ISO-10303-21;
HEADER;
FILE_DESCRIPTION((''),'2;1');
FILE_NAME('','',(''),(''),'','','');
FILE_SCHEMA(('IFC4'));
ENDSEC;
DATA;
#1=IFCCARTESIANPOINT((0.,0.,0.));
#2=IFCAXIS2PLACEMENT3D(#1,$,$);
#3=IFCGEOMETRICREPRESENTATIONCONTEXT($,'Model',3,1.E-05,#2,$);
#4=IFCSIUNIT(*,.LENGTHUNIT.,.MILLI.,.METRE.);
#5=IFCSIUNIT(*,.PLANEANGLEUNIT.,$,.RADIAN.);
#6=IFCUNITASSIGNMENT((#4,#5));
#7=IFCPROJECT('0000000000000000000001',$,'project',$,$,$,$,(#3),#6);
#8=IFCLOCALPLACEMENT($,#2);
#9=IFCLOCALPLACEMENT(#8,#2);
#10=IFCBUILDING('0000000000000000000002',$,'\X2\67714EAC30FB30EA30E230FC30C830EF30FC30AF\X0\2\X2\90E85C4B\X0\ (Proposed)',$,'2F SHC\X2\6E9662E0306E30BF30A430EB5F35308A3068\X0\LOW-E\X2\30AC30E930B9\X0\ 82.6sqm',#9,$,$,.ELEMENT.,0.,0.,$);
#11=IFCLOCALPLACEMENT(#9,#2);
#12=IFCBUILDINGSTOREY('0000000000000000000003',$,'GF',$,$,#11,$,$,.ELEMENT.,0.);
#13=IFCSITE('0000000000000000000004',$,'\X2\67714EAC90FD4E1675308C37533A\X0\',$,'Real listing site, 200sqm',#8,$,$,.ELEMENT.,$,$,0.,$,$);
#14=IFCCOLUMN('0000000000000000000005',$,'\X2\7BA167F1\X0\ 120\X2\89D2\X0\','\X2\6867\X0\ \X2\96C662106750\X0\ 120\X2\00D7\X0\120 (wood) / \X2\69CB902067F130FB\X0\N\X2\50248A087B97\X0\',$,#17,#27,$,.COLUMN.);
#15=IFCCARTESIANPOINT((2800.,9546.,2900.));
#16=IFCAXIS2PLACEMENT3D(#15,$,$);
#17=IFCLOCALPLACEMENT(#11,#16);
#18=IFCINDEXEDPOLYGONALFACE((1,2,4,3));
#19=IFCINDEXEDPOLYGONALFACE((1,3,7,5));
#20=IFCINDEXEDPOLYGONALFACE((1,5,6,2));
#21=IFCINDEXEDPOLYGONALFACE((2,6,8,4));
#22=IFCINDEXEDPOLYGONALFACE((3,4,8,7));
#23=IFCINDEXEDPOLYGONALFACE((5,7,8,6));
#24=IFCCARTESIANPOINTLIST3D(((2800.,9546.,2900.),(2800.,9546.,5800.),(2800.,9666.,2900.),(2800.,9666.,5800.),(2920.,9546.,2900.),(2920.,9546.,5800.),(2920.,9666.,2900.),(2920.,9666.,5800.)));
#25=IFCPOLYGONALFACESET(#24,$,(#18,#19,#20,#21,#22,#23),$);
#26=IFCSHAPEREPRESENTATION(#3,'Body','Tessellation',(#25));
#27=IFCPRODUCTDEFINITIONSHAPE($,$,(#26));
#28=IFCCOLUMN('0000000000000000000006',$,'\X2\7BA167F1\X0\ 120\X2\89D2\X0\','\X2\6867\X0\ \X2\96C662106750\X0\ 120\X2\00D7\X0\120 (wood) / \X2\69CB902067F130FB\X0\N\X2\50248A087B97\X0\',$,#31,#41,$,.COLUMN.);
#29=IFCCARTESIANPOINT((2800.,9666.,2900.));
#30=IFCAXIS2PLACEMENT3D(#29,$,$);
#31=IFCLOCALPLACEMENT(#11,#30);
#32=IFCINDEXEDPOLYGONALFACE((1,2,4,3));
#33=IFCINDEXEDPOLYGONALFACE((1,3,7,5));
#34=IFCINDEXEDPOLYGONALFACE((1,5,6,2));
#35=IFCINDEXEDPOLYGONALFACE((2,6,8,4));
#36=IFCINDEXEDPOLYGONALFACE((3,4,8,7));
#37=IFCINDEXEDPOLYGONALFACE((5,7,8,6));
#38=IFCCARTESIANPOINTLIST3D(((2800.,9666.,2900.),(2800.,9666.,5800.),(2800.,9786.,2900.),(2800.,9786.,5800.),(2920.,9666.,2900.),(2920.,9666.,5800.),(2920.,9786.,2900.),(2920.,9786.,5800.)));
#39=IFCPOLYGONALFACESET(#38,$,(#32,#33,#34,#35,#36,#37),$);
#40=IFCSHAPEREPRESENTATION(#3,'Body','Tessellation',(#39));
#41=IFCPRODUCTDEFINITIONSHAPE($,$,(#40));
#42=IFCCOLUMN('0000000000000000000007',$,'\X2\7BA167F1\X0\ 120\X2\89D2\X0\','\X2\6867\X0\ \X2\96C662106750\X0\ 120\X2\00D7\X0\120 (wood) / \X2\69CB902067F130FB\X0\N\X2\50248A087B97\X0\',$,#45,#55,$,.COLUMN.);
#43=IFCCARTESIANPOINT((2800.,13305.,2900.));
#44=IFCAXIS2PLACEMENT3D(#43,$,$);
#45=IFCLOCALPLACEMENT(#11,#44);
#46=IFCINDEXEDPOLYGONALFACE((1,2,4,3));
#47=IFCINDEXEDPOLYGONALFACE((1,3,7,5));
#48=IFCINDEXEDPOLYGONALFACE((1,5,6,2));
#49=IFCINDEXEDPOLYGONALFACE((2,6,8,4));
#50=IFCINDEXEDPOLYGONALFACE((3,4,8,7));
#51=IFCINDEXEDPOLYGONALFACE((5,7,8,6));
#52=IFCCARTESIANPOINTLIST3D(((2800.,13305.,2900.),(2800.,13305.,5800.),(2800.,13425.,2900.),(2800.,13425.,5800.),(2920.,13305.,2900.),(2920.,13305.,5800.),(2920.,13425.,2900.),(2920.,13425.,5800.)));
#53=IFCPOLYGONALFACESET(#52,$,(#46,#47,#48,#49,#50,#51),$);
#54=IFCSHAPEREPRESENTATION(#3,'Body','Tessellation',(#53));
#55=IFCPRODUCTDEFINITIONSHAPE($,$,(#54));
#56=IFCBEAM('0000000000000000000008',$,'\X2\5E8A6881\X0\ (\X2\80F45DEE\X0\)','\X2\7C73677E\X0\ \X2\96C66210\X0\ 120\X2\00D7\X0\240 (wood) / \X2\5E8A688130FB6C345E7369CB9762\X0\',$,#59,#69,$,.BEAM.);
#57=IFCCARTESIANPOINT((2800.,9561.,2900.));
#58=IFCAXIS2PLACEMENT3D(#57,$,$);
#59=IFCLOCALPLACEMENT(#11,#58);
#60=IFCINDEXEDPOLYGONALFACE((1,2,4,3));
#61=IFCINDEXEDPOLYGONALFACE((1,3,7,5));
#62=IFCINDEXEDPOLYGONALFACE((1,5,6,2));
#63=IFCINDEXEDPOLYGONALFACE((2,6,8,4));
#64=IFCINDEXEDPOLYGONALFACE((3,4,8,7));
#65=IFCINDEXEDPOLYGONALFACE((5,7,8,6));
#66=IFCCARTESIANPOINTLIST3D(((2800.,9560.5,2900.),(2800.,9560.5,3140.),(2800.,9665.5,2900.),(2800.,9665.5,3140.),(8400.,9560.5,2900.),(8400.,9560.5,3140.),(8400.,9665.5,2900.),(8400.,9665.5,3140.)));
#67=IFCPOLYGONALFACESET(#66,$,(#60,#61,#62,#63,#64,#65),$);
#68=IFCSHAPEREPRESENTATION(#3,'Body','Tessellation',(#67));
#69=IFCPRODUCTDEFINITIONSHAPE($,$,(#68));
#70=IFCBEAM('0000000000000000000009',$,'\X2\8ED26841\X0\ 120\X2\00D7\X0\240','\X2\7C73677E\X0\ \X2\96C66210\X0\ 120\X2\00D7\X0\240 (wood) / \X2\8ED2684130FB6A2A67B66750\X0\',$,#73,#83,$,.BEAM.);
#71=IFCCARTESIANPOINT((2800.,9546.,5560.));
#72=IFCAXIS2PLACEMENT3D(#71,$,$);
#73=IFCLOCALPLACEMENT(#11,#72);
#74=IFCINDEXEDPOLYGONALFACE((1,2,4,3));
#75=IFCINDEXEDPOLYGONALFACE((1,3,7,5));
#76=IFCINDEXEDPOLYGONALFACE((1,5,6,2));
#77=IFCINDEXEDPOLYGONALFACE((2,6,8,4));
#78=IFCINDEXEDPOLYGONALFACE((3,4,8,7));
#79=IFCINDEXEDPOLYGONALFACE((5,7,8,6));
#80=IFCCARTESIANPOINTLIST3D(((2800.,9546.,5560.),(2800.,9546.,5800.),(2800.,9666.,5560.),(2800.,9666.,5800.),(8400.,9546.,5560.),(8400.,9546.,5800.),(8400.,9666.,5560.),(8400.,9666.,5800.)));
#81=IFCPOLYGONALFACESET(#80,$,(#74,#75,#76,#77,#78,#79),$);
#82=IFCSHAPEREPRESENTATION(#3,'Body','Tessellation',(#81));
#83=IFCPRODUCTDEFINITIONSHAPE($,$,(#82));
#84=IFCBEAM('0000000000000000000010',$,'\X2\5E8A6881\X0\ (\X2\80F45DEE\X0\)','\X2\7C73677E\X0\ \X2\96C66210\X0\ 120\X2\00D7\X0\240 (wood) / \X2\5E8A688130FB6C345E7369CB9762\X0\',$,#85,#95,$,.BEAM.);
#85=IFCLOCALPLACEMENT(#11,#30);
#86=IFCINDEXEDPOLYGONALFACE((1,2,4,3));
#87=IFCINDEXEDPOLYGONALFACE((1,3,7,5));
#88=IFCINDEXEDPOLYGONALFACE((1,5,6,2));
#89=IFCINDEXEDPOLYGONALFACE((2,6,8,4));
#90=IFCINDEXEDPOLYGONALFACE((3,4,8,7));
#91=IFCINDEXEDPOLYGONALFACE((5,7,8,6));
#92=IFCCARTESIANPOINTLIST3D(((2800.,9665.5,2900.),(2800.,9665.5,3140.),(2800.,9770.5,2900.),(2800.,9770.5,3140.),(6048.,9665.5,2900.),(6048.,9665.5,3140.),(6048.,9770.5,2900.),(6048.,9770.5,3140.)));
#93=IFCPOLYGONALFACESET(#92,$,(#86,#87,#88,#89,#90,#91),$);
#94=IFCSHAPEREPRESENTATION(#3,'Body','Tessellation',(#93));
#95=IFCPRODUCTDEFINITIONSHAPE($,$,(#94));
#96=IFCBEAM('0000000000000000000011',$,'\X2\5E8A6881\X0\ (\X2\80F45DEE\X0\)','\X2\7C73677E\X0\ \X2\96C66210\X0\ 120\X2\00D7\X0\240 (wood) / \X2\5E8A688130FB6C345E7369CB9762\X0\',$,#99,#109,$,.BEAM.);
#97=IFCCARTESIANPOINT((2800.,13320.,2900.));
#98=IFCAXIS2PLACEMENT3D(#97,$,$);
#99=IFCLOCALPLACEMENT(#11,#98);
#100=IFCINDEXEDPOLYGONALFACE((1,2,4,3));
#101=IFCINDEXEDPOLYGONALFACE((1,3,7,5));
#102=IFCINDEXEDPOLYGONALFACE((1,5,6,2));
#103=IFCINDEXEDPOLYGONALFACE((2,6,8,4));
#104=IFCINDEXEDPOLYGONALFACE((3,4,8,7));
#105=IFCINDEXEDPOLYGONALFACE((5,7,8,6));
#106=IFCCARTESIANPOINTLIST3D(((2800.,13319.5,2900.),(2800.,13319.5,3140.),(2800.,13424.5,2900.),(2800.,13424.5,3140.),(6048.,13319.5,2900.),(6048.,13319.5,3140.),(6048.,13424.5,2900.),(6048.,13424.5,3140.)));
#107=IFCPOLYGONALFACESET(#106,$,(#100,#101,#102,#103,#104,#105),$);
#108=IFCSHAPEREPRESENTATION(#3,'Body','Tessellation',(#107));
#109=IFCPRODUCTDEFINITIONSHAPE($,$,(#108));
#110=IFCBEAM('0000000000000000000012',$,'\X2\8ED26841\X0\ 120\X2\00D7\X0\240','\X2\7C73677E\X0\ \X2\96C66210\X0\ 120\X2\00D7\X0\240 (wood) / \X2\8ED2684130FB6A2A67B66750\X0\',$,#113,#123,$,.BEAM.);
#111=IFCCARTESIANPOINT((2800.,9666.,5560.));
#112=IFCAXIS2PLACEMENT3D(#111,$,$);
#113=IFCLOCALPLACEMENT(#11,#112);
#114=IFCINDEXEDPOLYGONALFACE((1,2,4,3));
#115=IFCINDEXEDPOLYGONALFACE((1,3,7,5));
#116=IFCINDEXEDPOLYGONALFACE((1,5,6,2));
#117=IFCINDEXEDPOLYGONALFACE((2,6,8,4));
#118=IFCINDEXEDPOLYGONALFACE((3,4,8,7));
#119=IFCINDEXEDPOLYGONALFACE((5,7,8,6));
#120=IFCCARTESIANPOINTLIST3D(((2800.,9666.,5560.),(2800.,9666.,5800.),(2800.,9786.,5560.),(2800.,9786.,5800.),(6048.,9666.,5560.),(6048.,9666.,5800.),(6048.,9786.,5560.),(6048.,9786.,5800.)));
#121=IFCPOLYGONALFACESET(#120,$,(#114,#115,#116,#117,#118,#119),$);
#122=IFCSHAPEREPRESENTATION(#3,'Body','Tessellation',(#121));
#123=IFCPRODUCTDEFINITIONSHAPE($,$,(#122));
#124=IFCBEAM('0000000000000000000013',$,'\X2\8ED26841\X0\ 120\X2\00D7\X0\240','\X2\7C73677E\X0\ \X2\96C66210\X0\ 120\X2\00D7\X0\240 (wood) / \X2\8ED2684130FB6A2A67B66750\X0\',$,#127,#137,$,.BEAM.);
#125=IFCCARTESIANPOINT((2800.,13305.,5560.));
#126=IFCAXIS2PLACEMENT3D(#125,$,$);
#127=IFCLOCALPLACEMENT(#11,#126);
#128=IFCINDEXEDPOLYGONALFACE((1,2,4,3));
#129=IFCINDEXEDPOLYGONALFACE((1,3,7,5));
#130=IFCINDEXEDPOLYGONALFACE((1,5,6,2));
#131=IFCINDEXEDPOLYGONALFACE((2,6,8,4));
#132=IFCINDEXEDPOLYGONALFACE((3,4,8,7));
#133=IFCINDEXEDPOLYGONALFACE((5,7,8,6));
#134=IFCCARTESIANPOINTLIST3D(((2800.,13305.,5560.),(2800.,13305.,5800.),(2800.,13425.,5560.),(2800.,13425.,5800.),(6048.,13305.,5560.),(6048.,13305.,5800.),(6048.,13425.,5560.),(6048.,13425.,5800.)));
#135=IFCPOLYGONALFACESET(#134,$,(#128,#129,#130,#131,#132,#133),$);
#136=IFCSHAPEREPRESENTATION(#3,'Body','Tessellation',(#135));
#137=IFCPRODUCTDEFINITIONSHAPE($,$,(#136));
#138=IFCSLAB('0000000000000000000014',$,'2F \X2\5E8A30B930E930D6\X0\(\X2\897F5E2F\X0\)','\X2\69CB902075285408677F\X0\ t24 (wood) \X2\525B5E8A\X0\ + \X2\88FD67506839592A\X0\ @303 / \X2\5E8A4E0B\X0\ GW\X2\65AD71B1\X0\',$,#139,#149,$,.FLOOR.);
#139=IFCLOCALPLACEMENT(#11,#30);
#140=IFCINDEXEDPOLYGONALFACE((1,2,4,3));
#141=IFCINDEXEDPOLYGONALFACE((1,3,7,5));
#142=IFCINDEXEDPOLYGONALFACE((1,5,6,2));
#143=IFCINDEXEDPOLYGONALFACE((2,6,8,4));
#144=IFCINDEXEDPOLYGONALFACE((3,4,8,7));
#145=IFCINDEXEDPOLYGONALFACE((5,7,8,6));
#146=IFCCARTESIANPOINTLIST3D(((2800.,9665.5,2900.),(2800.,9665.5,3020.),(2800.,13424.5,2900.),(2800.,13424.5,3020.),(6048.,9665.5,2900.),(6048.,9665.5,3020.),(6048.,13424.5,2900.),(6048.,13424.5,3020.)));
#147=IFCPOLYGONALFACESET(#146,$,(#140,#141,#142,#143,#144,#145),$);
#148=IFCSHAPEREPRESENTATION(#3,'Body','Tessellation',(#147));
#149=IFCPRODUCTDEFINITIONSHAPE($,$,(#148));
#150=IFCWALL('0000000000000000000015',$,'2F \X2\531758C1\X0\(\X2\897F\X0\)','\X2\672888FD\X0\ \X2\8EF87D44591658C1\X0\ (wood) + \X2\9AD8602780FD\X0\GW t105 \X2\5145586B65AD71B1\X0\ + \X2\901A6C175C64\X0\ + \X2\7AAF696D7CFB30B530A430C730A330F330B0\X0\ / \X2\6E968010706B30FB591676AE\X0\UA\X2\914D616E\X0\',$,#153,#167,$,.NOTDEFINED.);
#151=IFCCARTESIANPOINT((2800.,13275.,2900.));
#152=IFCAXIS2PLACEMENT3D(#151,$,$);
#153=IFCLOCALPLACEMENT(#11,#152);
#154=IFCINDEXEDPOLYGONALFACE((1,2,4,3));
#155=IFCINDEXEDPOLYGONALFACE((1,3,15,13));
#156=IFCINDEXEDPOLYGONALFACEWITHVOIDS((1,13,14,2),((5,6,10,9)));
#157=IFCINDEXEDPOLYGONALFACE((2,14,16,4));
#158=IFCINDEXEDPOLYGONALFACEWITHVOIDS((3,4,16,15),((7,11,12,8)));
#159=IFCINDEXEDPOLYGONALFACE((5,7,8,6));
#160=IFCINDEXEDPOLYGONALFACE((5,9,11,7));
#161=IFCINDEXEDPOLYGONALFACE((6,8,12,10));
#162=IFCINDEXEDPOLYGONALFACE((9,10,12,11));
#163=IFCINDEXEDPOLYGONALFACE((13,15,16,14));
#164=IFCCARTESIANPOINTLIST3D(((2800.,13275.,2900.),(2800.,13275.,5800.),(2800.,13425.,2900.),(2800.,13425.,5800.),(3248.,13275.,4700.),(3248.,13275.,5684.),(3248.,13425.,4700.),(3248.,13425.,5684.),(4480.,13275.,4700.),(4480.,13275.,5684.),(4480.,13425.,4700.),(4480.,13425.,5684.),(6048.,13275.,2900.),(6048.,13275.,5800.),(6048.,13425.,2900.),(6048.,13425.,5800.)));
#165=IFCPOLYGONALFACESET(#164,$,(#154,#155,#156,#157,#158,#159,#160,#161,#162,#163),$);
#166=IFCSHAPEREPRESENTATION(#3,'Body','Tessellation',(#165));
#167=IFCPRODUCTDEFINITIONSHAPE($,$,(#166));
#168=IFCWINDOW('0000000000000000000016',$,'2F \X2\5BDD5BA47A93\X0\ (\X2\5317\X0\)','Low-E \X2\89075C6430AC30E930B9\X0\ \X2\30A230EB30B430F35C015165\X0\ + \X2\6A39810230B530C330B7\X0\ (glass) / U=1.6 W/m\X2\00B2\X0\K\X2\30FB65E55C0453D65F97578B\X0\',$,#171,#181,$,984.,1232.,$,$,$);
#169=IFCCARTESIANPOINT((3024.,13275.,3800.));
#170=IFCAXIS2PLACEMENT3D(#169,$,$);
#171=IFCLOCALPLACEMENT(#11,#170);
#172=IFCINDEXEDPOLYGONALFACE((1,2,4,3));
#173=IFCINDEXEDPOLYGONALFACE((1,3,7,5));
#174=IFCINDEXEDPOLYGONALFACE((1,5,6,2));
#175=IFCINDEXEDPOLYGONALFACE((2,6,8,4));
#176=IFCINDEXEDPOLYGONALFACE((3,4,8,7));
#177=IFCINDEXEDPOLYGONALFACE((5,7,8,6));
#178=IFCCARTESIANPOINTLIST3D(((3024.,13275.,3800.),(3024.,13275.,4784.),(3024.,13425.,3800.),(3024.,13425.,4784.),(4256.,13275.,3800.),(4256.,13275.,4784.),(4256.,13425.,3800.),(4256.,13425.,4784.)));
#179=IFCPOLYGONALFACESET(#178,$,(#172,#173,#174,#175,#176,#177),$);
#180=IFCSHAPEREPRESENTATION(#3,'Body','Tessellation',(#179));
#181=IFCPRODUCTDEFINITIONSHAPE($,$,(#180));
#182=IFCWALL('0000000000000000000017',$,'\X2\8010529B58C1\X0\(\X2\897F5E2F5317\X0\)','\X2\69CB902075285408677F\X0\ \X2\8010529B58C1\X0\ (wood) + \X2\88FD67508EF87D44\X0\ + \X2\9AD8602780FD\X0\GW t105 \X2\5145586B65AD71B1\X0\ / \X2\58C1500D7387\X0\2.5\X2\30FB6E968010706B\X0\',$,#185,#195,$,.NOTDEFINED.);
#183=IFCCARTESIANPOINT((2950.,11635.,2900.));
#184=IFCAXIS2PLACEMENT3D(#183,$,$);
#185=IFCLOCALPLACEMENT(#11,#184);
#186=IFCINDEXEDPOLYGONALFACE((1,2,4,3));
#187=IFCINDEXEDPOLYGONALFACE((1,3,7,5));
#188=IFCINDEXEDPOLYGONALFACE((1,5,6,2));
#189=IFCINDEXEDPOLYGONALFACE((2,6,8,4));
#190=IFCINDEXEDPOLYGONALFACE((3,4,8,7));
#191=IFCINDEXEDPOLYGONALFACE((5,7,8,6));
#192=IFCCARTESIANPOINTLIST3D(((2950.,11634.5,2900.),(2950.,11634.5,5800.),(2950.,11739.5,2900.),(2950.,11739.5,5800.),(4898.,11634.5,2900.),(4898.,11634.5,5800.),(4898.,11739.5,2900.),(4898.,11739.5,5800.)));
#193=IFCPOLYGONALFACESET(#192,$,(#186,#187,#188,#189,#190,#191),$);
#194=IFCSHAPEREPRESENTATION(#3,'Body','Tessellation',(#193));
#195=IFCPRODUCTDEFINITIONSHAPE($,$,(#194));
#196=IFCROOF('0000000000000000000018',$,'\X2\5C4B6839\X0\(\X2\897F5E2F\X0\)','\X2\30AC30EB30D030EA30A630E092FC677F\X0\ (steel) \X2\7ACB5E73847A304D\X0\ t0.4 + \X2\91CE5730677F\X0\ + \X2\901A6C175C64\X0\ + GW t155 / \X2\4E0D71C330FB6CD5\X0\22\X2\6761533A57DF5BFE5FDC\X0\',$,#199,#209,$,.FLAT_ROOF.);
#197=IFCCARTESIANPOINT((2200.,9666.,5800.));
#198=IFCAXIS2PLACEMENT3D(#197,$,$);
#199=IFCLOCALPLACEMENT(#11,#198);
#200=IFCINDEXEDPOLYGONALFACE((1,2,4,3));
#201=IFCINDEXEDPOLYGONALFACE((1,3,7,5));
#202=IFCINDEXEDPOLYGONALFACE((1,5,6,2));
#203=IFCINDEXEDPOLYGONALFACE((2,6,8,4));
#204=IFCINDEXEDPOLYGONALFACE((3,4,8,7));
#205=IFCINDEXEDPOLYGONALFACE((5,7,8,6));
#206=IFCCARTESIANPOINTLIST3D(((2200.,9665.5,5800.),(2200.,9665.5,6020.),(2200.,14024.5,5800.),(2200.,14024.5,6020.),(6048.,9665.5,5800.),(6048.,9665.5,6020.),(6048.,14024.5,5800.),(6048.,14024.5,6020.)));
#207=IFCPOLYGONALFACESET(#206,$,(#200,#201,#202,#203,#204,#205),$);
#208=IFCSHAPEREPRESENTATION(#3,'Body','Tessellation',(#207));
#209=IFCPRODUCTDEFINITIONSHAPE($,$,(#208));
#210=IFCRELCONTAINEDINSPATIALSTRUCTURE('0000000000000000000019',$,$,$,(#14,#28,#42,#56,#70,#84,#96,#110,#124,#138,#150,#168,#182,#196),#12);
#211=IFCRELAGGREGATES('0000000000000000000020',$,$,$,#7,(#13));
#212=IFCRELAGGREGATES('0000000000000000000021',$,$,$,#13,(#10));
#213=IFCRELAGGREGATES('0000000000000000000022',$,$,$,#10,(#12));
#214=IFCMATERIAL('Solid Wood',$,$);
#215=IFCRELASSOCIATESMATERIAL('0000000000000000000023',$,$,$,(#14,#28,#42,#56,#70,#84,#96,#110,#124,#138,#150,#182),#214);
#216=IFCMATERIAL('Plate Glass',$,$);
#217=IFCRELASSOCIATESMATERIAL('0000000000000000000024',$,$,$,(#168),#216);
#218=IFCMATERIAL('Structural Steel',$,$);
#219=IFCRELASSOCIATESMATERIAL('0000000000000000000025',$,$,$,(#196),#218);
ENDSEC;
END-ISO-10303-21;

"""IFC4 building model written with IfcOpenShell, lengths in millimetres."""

from ifc_helpers import new_model, si_unit, frame, frame_2d, origin, place, context, project, spatial, rectangle, extrude, material, element, fill, save


model = new_model("IFC4")

# Units and contexts
model_context = context("Model", 3, precision=1e-05, world=origin())
ifc_project = project(units=[si_unit("LENGTHUNIT", "METRE", prefix="MILLI"), si_unit("PLANEANGLEUNIT", "RADIAN")], contexts=[model_context])

# Site, building, storey
site_placement = place(None, origin())
site = spatial("IfcSite", under=ifc_project, at=site_placement, Name="東京都世田谷区", ObjectType="Real listing site, 200sqm", CompositionType="ELEMENT", RefElevation=0.0)
building_placement = place(site_placement, origin())
building = spatial("IfcBuilding", under=site, at=building_placement, Name="東京・リモートワーク2部屋 (Proposed)", ObjectType="2F SHC準拠のタイル張りとLOW-Eガラス 82.6sqm", CompositionType="ELEMENT", ElevationOfRefHeight=0.0, ElevationOfTerrain=0.0)
storey_placement = place(building_placement, origin())
storey = spatial("IfcBuildingStorey", under=building, at=storey_placement, Name="GF", CompositionType="ELEMENT", Elevation=0.0)

# Columns
ifc_material_1 = material(Name="Solid Wood")
column_1_placement = place(storey_placement, frame((2800.0, 9546.0, 2900.0)))
element("IfcColumn", 1, at=column_1_placement, inside=storey, material=ifc_material_1, Name="管柱 120角", Description="桧 集成材 120×120 (wood) / 構造柱・N値計算", PredefinedType="COLUMN", context=model_context, shape_type="SweptSolid", body=[
    extrude(rectangle(XDim=120.0, YDim=120.0, at=frame_2d((60.0, 60.0))), frame((2800.0, 9546.0, 2900.0)), (0.0, 0.0, 1.0), 2900.0),
])
column_2_placement = place(storey_placement, frame((2800.0, 9666.0, 2900.0)))
element("IfcColumn", 2, at=column_2_placement, inside=storey, material=ifc_material_1, Name="管柱 120角", Description="桧 集成材 120×120 (wood) / 構造柱・N値計算", PredefinedType="COLUMN", context=model_context, shape_type="SweptSolid", body=[
    extrude(rectangle(XDim=120.0, YDim=120.0, at=frame_2d((60.0, 60.0))), frame((2800.0, 9666.0, 2900.0)), (0.0, 0.0, 1.0), 2900.0),
])
column_3_placement = place(storey_placement, frame((2800.0, 13305.0, 2900.0)))
element("IfcColumn", 3, at=column_3_placement, inside=storey, material=ifc_material_1, Name="管柱 120角", Description="桧 集成材 120×120 (wood) / 構造柱・N値計算", PredefinedType="COLUMN", context=model_context, shape_type="SweptSolid", body=[
    extrude(rectangle(XDim=120.0, YDim=120.0, at=frame_2d((60.0, 60.0))), frame((2800.0, 13305.0, 2900.0)), (0.0, 0.0, 1.0), 2900.0),
])

# Beams
beam_1_placement = place(storey_placement, frame((2800.0, 9561.0, 2900.0)))
element("IfcBeam", 4, at=beam_1_placement, inside=storey, material=ifc_material_1, Name="床梁 (胴差)", Description="米松 集成 120×240 (wood) / 床梁・水平構面", PredefinedType="BEAM", context=model_context, shape_type="SweptSolid", body=[
    extrude(rectangle(XDim=5600.0, YDim=105.0, at=frame_2d((2800.0, 52.0))), frame((2800.0, 9561.0, 2900.0)), (0.0, 0.0, 1.0), 240.0),
])
beam_2_placement = place(storey_placement, frame((2800.0, 9546.0, 5560.0)))
element("IfcBeam", 5, at=beam_2_placement, inside=storey, material=ifc_material_1, Name="軒桁 120×240", Description="米松 集成 120×240 (wood) / 軒桁・横架材", PredefinedType="BEAM", context=model_context, shape_type="SweptSolid", body=[
    extrude(rectangle(XDim=5600.0, YDim=120.0, at=frame_2d((2800.0, 60.0))), frame((2800.0, 9546.0, 5560.0)), (0.0, 0.0, 1.0), 240.0),
])
beam_3_placement = place(storey_placement, frame((2800.0, 9666.0, 2900.0)))
element("IfcBeam", 6, at=beam_3_placement, inside=storey, material=ifc_material_1, Name="床梁 (胴差)", Description="米松 集成 120×240 (wood) / 床梁・水平構面", PredefinedType="BEAM", context=model_context, shape_type="SweptSolid", body=[
    extrude(rectangle(XDim=3248.0, YDim=105.0, at=frame_2d((1624.0, 52.0))), frame((2800.0, 9666.0, 2900.0)), (0.0, 0.0, 1.0), 240.0),
])
beam_4_placement = place(storey_placement, frame((2800.0, 13320.0, 2900.0)))
element("IfcBeam", 7, at=beam_4_placement, inside=storey, material=ifc_material_1, Name="床梁 (胴差)", Description="米松 集成 120×240 (wood) / 床梁・水平構面", PredefinedType="BEAM", context=model_context, shape_type="SweptSolid", body=[
    extrude(rectangle(XDim=3248.0, YDim=105.0, at=frame_2d((1624.0, 52.0))), frame((2800.0, 13320.0, 2900.0)), (0.0, 0.0, 1.0), 240.0),
])
beam_5_placement = place(storey_placement, frame((2800.0, 9666.0, 5560.0)))
element("IfcBeam", 8, at=beam_5_placement, inside=storey, material=ifc_material_1, Name="軒桁 120×240", Description="米松 集成 120×240 (wood) / 軒桁・横架材", PredefinedType="BEAM", context=model_context, shape_type="SweptSolid", body=[
    extrude(rectangle(XDim=3248.0, YDim=120.0, at=frame_2d((1624.0, 60.0))), frame((2800.0, 9666.0, 5560.0)), (0.0, 0.0, 1.0), 240.0),
])
beam_6_placement = place(storey_placement, frame((2800.0, 13305.0, 5560.0)))
element("IfcBeam", 9, at=beam_6_placement, inside=storey, material=ifc_material_1, Name="軒桁 120×240", Description="米松 集成 120×240 (wood) / 軒桁・横架材", PredefinedType="BEAM", context=model_context, shape_type="SweptSolid", body=[
    extrude(rectangle(XDim=3248.0, YDim=120.0, at=frame_2d((1624.0, 60.0))), frame((2800.0, 13305.0, 5560.0)), (0.0, 0.0, 1.0), 240.0),
])

# Slab
slab_placement = place(storey_placement, frame((2800.0, 9666.0, 2900.0)))
element("IfcSlab", 10, at=slab_placement, inside=storey, material=ifc_material_1, Name="2F 床スラブ(西帯)", Description="構造用合板 t24 (wood) 剛床 + 製材根太 @303 / 床下 GW断熱", PredefinedType="FLOOR", context=model_context, shape_type="SweptSolid", body=[
    extrude(rectangle(XDim=3248.0, YDim=3759.0, at=frame_2d((1624.0, 1879.0))), frame((2800.0, 9666.0, 2900.0)), (0.0, 0.0, 1.0), 120.0),
])

# Wall, opening, window
wall_1_placement = place(storey_placement, frame((2800.0, 13275.0, 2900.0)))
wall_1 = element("IfcWall", 11, at=wall_1_placement, inside=storey, material=ifc_material_1, Name="2F 北壁(西)", Description="木製 軸組外壁 (wood) + 高性能GW t105 充填断熱 + 通気層 + 窯業系サイディング / 準耐火・外皮UA配慮", PredefinedType="NOTDEFINED", context=model_context, shape_type="SweptSolid", body=[
    extrude(rectangle(XDim=3248.0, YDim=150.0, at=frame_2d((1624.0, 75.0))), frame((2800.0, 13275.0, 2900.0)), (0.0, 0.0, 1.0), 2900.0),
])
opening_placement = place(storey_placement, frame((3024.0, 13275.0, 3800.0)))
opening = element("IfcOpeningElement", 12, at=opening_placement, cuts=wall_1, PredefinedType="NOTDEFINED", context=model_context, shape_type="SweptSolid", body=[
    extrude(rectangle(XDim=1232.0, YDim=150.0, at=frame_2d((616.0, 75.0))), frame((3024.0, 13275.0, 3800.0)), (0.0, 0.0, 1.0), 984.0),
])
ifc_material_2 = material(Name="Plate Glass")
window_placement = place(storey_placement, frame((3024.0, 13275.0, 3800.0)))
window = element("IfcWindow", 13, at=window_placement, inside=storey, material=ifc_material_2, Name="2F 寝室窓 (北)", Description="Low-E 複層ガラス アルゴン封入 + 樹脂サッシ (glass) / U=1.6 W/m²K・日射取得型", OverallHeight=984.0, OverallWidth=1232.0, context=model_context, shape_type="SweptSolid", body=[
    extrude(rectangle(XDim=1232.0, YDim=150.0, at=frame_2d((616.0, 75.0))), frame((3024.0, 13275.0, 3800.0)), (0.0, 0.0, 1.0), 984.0),
])
fill(opening, window)

# Wall
wall_2_placement = place(storey_placement, frame((2950.0, 11635.0, 2900.0)))
element("IfcWall", 14, at=wall_2_placement, inside=storey, material=ifc_material_1, Name="耐力壁(西帯北)", Description="構造用合板 耐力壁 (wood) + 製材軸組 + 高性能GW t105 充填断熱 / 壁倍率2.5・準耐火", PredefinedType="NOTDEFINED", context=model_context, shape_type="SweptSolid", body=[
    extrude(rectangle(XDim=1948.0, YDim=105.0, at=frame_2d((974.0, 52.0))), frame((2950.0, 11635.0, 2900.0)), (0.0, 0.0, 1.0), 2900.0),
])

# Roof
ifc_material_3 = material(Name="Structural Steel")
for number, where, name in (
    (15, (2200.0, 9666.0, 5800.0), "屋根(西帯)"),
):
    element("IfcRoof", number, at=place(storey_placement, frame(where)), inside=storey, material=ifc_material_3, Name=name, Description="ガルバリウム鋼板 (steel) 立平葺き t0.4 + 野地板 + 通気層 + GW t155 / 不燃・法22条区域対応", PredefinedType="FLAT_ROOF", context=model_context, shape_type="SweptSolid", body=[
        extrude(rectangle(XDim=3848.0, YDim=4359.0, at=frame_2d((1924.0, 2179.0))), frame((2200.0, 9666.0, 5800.0)), (0.0, 0.0, 1.0), 220.0),
    ])

save(model, "model.ifc")
